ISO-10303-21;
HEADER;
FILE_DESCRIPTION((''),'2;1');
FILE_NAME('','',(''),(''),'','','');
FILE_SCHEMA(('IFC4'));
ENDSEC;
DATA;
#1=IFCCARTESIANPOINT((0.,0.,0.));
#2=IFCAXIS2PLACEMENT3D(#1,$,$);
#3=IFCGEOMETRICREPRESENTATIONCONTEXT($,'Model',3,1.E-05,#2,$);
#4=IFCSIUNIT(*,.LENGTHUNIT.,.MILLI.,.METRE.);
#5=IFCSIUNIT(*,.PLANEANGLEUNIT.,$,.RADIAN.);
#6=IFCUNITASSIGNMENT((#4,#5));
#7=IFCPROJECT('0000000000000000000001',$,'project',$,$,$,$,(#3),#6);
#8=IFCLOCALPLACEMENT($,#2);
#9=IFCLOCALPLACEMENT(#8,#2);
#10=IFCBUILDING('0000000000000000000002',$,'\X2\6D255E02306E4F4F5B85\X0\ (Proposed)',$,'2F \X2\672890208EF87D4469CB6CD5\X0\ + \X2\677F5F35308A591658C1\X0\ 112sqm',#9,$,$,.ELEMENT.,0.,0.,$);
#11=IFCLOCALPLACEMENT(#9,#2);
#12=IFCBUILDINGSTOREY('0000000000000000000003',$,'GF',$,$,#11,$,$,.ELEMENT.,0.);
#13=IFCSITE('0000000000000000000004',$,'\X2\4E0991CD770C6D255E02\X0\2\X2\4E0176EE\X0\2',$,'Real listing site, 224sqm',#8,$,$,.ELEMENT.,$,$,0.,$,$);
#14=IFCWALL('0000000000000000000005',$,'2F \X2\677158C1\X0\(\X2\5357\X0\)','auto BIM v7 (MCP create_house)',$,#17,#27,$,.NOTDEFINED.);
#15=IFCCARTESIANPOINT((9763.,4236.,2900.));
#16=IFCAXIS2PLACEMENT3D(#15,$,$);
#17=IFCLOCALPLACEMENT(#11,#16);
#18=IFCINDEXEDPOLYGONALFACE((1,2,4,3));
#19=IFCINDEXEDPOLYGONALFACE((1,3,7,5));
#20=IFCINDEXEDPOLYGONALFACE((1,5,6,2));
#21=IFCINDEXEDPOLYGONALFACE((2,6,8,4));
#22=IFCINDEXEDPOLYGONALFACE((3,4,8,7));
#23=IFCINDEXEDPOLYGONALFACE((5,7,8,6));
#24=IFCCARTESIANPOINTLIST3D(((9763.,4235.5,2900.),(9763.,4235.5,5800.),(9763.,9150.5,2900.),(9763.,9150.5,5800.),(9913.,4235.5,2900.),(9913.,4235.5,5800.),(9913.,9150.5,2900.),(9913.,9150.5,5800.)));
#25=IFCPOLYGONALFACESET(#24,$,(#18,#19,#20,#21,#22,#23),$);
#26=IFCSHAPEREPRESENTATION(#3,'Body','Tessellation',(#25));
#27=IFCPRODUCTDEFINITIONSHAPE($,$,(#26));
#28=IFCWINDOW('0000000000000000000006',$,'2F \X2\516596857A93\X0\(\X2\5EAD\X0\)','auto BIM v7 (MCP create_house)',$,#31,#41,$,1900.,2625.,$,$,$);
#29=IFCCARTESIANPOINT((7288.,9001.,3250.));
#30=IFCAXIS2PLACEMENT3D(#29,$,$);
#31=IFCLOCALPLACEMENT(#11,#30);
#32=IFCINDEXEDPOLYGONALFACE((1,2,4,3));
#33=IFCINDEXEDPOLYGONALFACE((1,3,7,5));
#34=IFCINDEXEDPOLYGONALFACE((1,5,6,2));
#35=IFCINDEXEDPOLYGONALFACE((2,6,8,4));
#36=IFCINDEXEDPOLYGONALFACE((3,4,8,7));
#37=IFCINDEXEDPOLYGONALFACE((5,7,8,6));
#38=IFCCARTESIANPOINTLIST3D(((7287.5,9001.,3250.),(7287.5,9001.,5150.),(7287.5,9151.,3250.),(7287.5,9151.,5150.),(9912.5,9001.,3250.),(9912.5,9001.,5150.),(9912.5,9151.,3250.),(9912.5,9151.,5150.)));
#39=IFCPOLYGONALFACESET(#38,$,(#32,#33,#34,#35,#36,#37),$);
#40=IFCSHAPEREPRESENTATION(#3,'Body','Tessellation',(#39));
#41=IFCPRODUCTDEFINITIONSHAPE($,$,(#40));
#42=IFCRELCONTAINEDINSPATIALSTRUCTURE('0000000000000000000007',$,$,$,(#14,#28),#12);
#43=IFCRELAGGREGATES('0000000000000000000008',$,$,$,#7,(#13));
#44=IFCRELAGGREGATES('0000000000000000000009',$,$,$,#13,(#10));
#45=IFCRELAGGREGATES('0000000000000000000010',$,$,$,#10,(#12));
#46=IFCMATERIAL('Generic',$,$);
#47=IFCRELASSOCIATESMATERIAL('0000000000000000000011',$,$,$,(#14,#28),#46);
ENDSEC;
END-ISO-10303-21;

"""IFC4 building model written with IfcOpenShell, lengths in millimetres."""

from ifc_helpers import new_model, si_unit, frame, frame_2d, origin, place, context, project, spatial, rectangle, extrude, material, element, fill, save


model = new_model("IFC4")

# Units and contexts
model_context = context("Model", 3, precision=1e-05, world=origin())
ifc_project = project(units=[si_unit("LENGTHUNIT", "METRE", prefix="MILLI"), si_unit("PLANEANGLEUNIT", "RADIAN")], contexts=[model_context])

# Site, building, storey
site_placement = place(None, origin())
site = spatial("IfcSite", under=ifc_project, at=site_placement, Name="三重県津市2丁目2", ObjectType="Real listing site, 224sqm", CompositionType="ELEMENT", RefElevation=0.0)
building_placement = place(site_placement, origin())
building = spatial("IfcBuilding", under=site, at=building_placement, Name="津市の住宅 (Proposed)", ObjectType="2F 木造軸組構法 + 板張り外壁 112sqm", CompositionType="ELEMENT", ElevationOfRefHeight=0.0, ElevationOfTerrain=0.0)
storey_placement = place(building_placement, origin())
storey = spatial("IfcBuildingStorey", under=building, at=storey_placement, Name="GF", CompositionType="ELEMENT", Elevation=0.0)

# Shared definitions
ifc_material = material(Name="Generic")

# Wall, opening, window
wall_1_placement = place(storey_placement, frame((9763.0, 4236.0, 2900.0)))
wall_1 = element("IfcWall", 1, at=wall_1_placement, inside=storey, material=ifc_material, Name="2F 東壁(南)", Description="auto BIM v7 (MCP create_house)", PredefinedType="NOTDEFINED", context=model_context, shape_type="SweptSolid", body=[
    extrude(rectangle(XDim=150.0, YDim=4915.0, at=frame_2d((75.0, 2457.0))), frame((9763.0, 4236.0, 2900.0)), (0.0, 0.0, 1.0), 2900.0),
])
opening_1_placement = place(storey_placement, frame((7288.0, 9001.0, 3250.0)))
opening_1 = element("IfcOpeningElement", 2, at=opening_1_placement, cuts=wall_1, PredefinedType="NOTDEFINED", context=model_context, shape_type="SweptSolid", body=[
    extrude(rectangle(XDim=2625.0, YDim=150.0, at=frame_2d((1312.0, 75.0))), frame((7288.0, 9001.0, 3250.0)), (0.0, 0.0, 1.0), 1900.0),
])
window_1_placement = place(storey_placement, frame((7288.0, 9001.0, 3250.0)))
window_1 = element("IfcWindow", 3, at=window_1_placement, inside=storey, material=ifc_material, Name="2F 入隅窓(庭)", Description="auto BIM v7 (MCP create_house)", OverallHeight=1900.0, OverallWidth=2625.0, context=model_context, shape_type="SweptSolid", body=[
    extrude(rectangle(XDim=2625.0, YDim=150.0, at=frame_2d((1312.0, 75.0))), frame((7288.0, 9001.0, 3250.0)), (0.0, 0.0, 1.0), 1900.0),
])
fill(opening_1, window_1)

save(model, "model.ifc")
